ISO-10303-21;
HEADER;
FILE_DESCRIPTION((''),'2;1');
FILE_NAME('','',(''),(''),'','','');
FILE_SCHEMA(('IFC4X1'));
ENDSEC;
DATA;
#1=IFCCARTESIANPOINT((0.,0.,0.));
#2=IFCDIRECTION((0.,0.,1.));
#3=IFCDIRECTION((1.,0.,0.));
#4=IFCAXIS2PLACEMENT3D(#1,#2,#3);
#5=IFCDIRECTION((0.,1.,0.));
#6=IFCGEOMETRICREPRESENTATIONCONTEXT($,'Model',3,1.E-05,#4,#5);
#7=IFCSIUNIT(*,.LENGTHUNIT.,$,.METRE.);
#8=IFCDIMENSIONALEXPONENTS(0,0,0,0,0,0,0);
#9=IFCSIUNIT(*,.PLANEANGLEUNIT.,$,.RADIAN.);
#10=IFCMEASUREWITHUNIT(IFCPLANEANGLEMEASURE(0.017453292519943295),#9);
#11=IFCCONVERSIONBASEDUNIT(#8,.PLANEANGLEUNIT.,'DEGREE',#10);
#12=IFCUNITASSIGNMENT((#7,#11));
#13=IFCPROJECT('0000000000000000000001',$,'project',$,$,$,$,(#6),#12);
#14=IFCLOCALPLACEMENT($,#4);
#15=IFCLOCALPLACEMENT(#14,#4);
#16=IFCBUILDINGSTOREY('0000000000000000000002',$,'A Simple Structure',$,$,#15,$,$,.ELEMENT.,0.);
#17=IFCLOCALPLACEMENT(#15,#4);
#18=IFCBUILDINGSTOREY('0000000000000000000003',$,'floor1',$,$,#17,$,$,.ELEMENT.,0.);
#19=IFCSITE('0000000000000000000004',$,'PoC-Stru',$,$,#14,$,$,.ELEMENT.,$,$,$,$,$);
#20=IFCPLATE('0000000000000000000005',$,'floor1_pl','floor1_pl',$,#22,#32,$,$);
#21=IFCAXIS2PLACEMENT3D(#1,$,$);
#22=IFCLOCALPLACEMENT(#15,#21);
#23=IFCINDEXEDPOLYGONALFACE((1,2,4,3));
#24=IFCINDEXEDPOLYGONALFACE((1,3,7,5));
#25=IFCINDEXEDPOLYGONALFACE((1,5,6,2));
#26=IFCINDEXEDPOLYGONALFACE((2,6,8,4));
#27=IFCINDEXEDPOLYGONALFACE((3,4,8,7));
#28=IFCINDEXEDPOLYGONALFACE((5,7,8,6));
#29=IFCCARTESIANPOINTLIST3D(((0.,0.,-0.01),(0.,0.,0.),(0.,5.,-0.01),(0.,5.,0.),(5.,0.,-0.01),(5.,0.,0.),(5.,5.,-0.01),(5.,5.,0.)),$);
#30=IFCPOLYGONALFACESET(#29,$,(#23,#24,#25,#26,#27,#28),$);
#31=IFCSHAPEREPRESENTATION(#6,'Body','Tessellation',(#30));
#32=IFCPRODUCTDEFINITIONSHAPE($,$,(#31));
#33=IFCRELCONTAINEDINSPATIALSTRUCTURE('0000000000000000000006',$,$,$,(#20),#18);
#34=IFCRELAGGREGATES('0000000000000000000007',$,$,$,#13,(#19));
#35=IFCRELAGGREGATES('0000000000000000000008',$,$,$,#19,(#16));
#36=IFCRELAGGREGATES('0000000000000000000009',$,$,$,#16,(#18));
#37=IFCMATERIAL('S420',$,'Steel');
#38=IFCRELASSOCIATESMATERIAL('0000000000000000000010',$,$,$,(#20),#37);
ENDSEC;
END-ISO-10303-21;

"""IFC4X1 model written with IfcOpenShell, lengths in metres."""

from ifc_helpers import new_model, entity, si_unit, converted_unit, direction, origin_with_axes, place, context, project, spatial, line, indexed_curve, outline, extrude, material, element, save


model = new_model("IFC4X1")

# Units and contexts
model_context = context("Model", 3, precision=1e-05, world=origin_with_axes(), true_north=direction((0.0, 1.0, 0.0)))
ifc_project = project(units=[si_unit("LENGTHUNIT", "METRE"), converted_unit("PLANEANGLEUNIT", "DEGREE", entity("IfcPlaneAngleMeasure", 0.017453292519943295), si_unit("PLANEANGLEUNIT", "RADIAN"), dimensions=[0, 0, 0, 0, 0, 0, 0])], contexts=[model_context])

# Site, storeys
site_placement = place(None, origin_with_axes())
site = spatial("IfcSite", under=ifc_project, at=site_placement, Name="PoC-Stru", CompositionType="ELEMENT")
storey_1_placement = place(site_placement, origin_with_axes())
storey_1 = spatial("IfcBuildingStorey", under=site, at=storey_1_placement, Name="A Simple Structure", CompositionType="ELEMENT", Elevation=0.0)
storey_2_placement = place(storey_1_placement, origin_with_axes())
storey_2 = spatial("IfcBuildingStorey", under=storey_1, at=storey_2_placement, Name="floor1", CompositionType="ELEMENT", Elevation=0.0)

# Plate
ifc_material = material(Name="S420", Category="Steel")
plate_placement = place(storey_2_placement, origin_with_axes())
element("IfcPlate", 1, at=plate_placement, inside=storey_2, material=ifc_material, Name="floor1_pl", Description="floor1_pl", context=model_context, shape_type="SolidModel", body=[
    extrude(outline(indexed_curve([(0.0, 5.0, 0.0), (0.0, 0.0, 0.0), (5.0, 0.0, 0.0), (5.0, 5.0, 0.0)], segments=[line(1, 2), line(2, 3), line(3, 4), line(4, 1)])), origin_with_axes(), (0.0, 0.0, -1.0), 0.01),
])

save(model, "model.ifc")
